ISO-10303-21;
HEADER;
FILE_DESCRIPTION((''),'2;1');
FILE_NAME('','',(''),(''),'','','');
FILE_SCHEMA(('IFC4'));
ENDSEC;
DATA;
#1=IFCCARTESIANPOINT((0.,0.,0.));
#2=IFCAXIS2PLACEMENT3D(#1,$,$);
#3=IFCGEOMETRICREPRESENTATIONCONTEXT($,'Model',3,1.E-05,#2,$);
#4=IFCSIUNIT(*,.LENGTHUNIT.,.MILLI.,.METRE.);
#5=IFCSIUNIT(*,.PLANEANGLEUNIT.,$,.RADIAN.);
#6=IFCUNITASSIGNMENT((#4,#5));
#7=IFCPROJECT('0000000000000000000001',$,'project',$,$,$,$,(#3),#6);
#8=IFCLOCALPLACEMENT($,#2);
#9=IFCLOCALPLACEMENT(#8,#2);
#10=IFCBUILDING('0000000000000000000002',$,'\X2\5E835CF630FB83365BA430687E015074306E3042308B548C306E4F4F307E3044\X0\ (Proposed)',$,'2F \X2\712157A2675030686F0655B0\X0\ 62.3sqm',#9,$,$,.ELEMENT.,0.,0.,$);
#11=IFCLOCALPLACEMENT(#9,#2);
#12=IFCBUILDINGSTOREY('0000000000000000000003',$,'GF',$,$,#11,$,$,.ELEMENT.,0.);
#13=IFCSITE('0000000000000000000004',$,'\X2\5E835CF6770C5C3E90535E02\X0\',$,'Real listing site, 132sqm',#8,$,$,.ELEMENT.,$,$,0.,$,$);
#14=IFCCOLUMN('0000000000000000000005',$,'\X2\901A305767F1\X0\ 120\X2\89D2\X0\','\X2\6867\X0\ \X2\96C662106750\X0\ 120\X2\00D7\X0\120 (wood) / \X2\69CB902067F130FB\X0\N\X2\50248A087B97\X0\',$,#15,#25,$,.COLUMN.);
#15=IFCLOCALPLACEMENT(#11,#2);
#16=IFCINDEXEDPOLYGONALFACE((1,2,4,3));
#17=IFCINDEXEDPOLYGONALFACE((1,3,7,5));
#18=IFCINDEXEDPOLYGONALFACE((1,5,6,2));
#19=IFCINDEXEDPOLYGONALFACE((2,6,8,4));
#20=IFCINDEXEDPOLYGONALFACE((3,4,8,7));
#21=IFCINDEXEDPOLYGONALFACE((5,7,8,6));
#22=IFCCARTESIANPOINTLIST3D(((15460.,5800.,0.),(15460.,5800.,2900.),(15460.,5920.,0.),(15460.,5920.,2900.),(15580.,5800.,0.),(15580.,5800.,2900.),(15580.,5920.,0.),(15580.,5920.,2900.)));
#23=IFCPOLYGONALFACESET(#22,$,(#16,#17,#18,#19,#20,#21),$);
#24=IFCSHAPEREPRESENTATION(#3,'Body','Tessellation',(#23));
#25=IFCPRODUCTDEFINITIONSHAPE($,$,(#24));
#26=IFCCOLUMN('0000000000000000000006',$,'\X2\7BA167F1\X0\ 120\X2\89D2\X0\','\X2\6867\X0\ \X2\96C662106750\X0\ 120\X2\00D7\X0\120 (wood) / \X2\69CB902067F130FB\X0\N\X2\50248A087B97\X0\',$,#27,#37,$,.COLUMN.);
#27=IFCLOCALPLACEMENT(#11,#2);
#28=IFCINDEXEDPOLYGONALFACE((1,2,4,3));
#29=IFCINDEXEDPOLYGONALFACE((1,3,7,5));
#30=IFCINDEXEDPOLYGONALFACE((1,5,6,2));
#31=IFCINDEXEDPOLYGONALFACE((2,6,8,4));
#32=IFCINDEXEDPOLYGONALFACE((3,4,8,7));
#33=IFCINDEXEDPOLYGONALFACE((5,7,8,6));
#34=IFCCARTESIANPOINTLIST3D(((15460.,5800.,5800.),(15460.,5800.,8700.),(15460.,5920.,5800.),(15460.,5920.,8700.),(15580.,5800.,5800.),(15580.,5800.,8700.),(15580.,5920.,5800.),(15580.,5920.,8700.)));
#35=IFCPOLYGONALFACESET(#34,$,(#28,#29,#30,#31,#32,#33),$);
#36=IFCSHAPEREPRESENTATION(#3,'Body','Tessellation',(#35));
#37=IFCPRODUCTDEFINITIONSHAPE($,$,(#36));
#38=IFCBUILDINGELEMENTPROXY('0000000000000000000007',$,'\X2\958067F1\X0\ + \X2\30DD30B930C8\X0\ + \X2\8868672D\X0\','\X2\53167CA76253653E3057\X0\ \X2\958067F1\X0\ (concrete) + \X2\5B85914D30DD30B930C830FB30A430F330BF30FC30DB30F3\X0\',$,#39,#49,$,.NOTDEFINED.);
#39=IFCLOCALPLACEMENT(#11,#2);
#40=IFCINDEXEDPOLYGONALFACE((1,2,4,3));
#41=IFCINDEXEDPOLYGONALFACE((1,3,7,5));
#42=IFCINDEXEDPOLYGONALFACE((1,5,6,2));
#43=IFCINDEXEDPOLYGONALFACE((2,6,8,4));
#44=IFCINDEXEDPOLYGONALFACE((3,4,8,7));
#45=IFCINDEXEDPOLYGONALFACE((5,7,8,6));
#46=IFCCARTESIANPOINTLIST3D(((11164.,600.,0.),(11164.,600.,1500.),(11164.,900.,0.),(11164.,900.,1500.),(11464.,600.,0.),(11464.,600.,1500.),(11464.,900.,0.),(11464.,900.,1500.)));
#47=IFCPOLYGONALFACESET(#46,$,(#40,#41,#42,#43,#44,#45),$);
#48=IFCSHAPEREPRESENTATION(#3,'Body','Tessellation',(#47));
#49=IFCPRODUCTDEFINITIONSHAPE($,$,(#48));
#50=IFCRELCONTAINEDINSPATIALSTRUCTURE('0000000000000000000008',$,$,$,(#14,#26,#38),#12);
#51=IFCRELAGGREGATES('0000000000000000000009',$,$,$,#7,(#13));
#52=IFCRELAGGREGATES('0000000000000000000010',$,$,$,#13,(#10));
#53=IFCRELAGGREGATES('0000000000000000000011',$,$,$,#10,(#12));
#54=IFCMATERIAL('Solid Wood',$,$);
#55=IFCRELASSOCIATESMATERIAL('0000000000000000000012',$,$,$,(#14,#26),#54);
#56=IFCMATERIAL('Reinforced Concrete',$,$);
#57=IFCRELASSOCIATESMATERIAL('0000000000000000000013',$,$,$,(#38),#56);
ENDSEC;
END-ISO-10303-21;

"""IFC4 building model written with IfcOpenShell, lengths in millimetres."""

from ifc_helpers import new_model, si_unit, frame, frame_2d, origin, place, context, project, spatial, rectangle, extrude, material, element, save


model = new_model("IFC4")

# Units and contexts
model_context = context("Model", 3, precision=1e-05, world=origin())
ifc_project = project(units=[si_unit("LENGTHUNIT", "METRE", prefix="MILLI"), si_unit("PLANEANGLEUNIT", "RADIAN")], contexts=[model_context])

# Site, building, storey
site_placement = place(None, origin())
site = spatial("IfcSite", under=ifc_project, at=site_placement, Name="広島県尾道市", ObjectType="Real listing site, 132sqm", CompositionType="ELEMENT", RefElevation=0.0)
building_placement = place(site_placement, origin())
building = spatial("IfcBuilding", under=site, at=building_placement, Name="広島・茶室と縁側のある和の住まい (Proposed)", ObjectType="2F 無垢材と漆喰 62.3sqm", CompositionType="ELEMENT", ElevationOfRefHeight=0.0, ElevationOfTerrain=0.0)
storey_placement = place(building_placement, origin())
storey = spatial("IfcBuildingStorey", under=building, at=storey_placement, Name="GF", CompositionType="ELEMENT", Elevation=0.0)

# Columns
ifc_material_1 = material(Name="Solid Wood")
column_1_placement = place(storey_placement, frame((7730.0, 2900.0, 0.0)))
element("IfcColumn", 1, at=column_1_placement, inside=storey, material=ifc_material_1, Name="通し柱 120角", Description="桧 集成材 120×120 (wood) / 構造柱・N値計算", PredefinedType="COLUMN", context=model_context, shape_type="SweptSolid", body=[
    extrude(rectangle(XDim=120.0, YDim=120.0, at=frame_2d((60.0, 60.0))), frame((7730.0, 2900.0, 0.0)), (0.0, 0.0, 1.0), 2900.0),
])
column_2_placement = place(storey_placement, frame((7730.0, 2900.0, 2900.0)))
element("IfcColumn", 2, at=column_2_placement, inside=storey, material=ifc_material_1, Name="管柱 120角", Description="桧 集成材 120×120 (wood) / 構造柱・N値計算", PredefinedType="COLUMN", context=model_context, shape_type="SweptSolid", body=[
    extrude(rectangle(XDim=120.0, YDim=120.0, at=frame_2d((60.0, 60.0))), frame((7730.0, 2900.0, 2900.0)), (0.0, 0.0, 1.0), 2900.0),
])

# Shared definitions
ifc_material_2 = material(Name="Reinforced Concrete")

# Building element proxy
proxy_placement = place(storey_placement, frame((5582.0, 300.0, 0.0)))
element("IfcBuildingElementProxy", 3, at=proxy_placement, inside=storey, material=ifc_material_2, Name="門柱 + ポスト + 表札", Description="化粧打放し 門柱 (concrete) + 宅配ポスト・インターホン", PredefinedType="NOTDEFINED", context=model_context, shape_type="SweptSolid", body=[
    extrude(rectangle(XDim=300.0, YDim=300.0, at=frame_2d((150.0, 150.0))), frame((5582.0, 300.0, 0.0)), (0.0, 0.0, 1.0), 1500.0),
])

save(model, "model.ifc")
